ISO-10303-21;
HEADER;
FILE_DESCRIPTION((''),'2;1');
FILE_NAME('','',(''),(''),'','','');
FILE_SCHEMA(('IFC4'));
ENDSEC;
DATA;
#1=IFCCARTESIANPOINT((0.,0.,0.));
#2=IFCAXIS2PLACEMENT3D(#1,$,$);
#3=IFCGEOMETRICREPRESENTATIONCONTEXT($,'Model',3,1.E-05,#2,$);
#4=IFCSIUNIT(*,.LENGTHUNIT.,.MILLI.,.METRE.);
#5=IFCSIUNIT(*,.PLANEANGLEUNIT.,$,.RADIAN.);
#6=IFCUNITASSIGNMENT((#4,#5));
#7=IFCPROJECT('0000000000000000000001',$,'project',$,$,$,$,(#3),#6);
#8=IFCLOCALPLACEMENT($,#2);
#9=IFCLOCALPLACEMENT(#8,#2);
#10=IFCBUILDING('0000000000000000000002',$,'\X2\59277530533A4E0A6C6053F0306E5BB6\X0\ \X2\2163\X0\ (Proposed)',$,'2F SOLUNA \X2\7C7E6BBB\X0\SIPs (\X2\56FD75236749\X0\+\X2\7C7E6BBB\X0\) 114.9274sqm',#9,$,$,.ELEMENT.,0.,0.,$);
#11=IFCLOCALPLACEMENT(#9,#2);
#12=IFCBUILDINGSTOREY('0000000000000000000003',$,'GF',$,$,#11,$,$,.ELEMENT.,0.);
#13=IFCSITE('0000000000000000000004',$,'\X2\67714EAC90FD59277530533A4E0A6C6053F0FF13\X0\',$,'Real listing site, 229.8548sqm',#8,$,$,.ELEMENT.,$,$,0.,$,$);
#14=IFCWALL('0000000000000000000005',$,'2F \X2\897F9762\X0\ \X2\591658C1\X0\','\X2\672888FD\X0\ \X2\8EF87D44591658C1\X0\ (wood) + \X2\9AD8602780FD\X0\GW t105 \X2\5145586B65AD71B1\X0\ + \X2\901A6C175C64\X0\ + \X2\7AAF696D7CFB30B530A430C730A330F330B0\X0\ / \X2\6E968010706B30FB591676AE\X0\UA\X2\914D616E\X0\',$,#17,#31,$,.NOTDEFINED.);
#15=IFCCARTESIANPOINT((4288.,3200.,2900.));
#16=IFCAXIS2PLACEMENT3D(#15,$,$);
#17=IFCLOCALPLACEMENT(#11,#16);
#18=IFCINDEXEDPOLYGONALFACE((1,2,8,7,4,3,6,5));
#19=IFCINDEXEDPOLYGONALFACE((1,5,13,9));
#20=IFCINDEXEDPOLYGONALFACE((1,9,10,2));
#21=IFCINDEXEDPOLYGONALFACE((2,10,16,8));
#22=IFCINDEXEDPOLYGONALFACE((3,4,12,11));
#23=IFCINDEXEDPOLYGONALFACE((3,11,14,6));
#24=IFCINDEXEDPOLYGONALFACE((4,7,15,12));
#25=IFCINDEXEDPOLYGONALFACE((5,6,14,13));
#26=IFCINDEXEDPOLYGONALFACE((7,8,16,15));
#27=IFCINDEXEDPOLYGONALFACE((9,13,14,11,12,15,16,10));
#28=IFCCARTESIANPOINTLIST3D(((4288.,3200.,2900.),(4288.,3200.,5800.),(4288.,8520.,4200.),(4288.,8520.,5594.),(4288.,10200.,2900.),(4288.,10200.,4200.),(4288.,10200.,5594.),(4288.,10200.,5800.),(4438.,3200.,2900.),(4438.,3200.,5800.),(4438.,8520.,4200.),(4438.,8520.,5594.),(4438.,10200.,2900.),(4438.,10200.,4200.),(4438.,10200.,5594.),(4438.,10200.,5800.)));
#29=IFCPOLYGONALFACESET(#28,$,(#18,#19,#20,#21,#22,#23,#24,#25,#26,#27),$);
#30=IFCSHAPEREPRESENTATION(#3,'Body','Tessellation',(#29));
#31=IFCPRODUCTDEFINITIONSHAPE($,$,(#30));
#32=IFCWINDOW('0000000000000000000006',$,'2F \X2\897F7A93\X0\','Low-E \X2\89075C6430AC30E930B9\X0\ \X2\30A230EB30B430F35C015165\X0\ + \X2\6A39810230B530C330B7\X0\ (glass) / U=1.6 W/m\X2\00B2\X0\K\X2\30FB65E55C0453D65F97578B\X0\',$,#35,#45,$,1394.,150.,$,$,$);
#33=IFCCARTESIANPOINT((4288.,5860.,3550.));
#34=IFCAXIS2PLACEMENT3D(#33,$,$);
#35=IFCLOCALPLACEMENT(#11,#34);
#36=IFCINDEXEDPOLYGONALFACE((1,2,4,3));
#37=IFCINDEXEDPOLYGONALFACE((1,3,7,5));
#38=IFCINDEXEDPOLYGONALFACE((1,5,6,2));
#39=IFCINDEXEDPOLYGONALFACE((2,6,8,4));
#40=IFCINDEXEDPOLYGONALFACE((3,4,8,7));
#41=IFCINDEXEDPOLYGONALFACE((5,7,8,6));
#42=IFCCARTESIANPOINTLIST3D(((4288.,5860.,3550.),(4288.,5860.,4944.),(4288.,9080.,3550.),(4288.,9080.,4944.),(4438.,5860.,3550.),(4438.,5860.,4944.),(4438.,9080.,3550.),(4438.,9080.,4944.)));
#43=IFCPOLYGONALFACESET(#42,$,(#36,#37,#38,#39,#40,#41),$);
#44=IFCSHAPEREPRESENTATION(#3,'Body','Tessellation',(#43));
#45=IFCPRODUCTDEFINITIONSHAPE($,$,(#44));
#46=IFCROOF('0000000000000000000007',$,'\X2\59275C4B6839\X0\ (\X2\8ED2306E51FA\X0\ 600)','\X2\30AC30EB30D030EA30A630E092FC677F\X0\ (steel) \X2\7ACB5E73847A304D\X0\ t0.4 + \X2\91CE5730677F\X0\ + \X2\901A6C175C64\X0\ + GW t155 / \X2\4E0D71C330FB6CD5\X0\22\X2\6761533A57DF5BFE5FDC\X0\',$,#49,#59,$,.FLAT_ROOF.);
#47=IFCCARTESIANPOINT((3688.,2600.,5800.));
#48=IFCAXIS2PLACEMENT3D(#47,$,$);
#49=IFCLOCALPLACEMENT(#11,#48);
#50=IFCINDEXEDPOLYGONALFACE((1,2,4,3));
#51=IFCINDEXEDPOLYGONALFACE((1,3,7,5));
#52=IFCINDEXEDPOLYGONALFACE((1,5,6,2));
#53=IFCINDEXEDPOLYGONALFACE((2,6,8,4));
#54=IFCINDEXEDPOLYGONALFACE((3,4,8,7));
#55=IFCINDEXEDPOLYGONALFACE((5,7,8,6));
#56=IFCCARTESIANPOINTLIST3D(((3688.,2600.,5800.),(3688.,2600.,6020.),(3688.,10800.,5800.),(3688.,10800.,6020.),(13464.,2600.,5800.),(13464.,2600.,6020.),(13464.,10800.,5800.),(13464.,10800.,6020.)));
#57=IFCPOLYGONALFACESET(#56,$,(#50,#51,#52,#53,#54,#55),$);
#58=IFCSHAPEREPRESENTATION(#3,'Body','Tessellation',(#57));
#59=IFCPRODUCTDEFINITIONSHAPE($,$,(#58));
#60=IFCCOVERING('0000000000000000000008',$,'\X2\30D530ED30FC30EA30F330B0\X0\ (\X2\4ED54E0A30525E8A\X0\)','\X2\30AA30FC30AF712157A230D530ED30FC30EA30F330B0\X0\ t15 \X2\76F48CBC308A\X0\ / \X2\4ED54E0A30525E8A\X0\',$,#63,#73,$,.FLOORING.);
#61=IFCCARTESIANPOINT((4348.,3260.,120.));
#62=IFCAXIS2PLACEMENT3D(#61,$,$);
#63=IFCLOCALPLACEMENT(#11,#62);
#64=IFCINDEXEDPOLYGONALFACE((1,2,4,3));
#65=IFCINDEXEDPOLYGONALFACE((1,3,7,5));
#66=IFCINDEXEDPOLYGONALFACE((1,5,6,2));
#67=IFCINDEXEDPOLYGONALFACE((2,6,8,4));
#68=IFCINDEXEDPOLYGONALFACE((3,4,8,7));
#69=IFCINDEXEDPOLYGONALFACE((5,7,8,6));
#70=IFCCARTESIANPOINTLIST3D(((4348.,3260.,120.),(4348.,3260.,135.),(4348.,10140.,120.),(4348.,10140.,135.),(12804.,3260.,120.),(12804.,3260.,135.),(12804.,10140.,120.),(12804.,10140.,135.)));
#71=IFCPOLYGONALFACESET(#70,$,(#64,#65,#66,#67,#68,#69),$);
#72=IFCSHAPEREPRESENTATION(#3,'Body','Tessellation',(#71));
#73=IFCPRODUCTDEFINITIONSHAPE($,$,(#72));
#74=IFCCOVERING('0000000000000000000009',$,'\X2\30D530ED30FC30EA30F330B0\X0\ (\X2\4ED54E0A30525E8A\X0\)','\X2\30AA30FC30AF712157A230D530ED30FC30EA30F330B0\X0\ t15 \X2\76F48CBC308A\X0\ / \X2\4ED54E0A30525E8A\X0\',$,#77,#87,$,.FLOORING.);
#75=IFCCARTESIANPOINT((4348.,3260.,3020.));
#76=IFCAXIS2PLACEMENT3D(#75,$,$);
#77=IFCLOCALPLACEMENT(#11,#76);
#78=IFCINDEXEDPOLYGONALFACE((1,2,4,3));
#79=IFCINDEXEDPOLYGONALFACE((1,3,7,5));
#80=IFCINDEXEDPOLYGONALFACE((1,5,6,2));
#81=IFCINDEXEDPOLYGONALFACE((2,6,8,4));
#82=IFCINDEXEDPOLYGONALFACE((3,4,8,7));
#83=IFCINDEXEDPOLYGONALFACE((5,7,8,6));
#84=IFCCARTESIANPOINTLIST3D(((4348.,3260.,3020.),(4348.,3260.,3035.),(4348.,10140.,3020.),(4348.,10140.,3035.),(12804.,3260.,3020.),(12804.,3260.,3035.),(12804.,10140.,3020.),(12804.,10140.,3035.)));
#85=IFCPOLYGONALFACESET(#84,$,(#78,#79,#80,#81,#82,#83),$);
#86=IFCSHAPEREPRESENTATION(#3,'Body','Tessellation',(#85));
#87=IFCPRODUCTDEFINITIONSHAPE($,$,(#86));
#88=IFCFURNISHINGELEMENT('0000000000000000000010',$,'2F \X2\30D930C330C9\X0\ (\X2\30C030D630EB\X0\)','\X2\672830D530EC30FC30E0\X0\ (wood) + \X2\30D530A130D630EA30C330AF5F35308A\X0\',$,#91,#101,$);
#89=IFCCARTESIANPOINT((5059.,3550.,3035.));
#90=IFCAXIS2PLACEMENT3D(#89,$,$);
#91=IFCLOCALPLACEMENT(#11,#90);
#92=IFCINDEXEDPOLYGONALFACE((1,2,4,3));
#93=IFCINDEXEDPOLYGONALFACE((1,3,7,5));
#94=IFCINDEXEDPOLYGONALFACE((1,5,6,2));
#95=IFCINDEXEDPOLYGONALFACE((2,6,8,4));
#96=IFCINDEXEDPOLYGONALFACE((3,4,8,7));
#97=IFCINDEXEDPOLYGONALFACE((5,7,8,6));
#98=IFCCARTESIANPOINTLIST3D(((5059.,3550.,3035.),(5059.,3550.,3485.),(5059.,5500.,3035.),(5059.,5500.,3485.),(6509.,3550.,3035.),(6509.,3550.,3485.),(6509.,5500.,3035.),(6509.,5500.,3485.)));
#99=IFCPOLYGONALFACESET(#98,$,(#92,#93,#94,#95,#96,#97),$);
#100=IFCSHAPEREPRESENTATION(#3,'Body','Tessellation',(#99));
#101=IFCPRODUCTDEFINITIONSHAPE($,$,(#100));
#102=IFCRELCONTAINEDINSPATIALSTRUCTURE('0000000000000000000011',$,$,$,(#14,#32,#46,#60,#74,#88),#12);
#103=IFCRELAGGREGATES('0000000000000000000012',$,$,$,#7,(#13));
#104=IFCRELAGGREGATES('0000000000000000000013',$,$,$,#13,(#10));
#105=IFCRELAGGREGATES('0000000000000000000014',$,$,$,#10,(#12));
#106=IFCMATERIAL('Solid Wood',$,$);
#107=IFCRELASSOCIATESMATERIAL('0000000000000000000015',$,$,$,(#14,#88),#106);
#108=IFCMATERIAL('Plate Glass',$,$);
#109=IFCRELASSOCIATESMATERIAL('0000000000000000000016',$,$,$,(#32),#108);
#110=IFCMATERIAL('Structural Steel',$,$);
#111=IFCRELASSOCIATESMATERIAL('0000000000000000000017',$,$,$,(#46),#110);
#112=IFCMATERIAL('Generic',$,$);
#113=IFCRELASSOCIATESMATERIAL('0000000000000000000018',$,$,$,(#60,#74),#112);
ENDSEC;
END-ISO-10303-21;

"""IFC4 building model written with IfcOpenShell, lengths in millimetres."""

from ifc_helpers import new_model, si_unit, frame, frame_2d, origin, place, context, project, spatial, rectangle, extrude, material, element, fill, save


model = new_model("IFC4")

# Units and contexts
model_context = context("Model", 3, precision=1e-05, world=origin())
ifc_project = project(units=[si_unit("LENGTHUNIT", "METRE", prefix="MILLI"), si_unit("PLANEANGLEUNIT", "RADIAN")], contexts=[model_context])

# Site, building, storey
site_placement = place(None, origin())
site = spatial("IfcSite", under=ifc_project, at=site_placement, Name="東京都大田区上池台３", ObjectType="Real listing site, 229.8548sqm", CompositionType="ELEMENT", RefElevation=0.0)
building_placement = place(site_placement, origin())
building = spatial("IfcBuilding", under=site, at=building_placement, Name="大田区上池台の家 Ⅳ (Proposed)", ObjectType="2F SOLUNA 籾殻SIPs (国産杉+籾殻) 114.9274sqm", CompositionType="ELEMENT", ElevationOfRefHeight=0.0, ElevationOfTerrain=0.0)
storey_placement = place(building_placement, origin())
storey = spatial("IfcBuildingStorey", under=building, at=storey_placement, Name="GF", CompositionType="ELEMENT", Elevation=0.0)

# Shared definitions
ifc_material_1 = material(Name="Solid Wood")

# Shared definitions
ifc_material_2 = material(Name="Plate Glass")

# Wall, opening, window
wall_1_placement = place(storey_placement, frame((4288.0, 3200.0, 2900.0)))
wall_1 = element("IfcWall", 1, at=wall_1_placement, inside=storey, material=ifc_material_1, Name="2F 西面 外壁", Description="木製 軸組外壁 (wood) + 高性能GW t105 充填断熱 + 通気層 + 窯業系サイディング / 準耐火・外皮UA配慮", PredefinedType="NOTDEFINED", context=model_context, shape_type="SweptSolid", body=[
    extrude(rectangle(XDim=150.0, YDim=7000.0, at=frame_2d((75.0, 3500.0))), frame((4288.0, 3200.0, 2900.0)), (0.0, 0.0, 1.0), 2900.0),
])
opening_1_placement = place(storey_placement, frame((4288.0, 5860.0, 3550.0)))
opening_1 = element("IfcOpeningElement", 2, at=opening_1_placement, cuts=wall_1, PredefinedType="NOTDEFINED", context=model_context, shape_type="SweptSolid", body=[
    extrude(rectangle(XDim=150.0, YDim=3220.0, at=frame_2d((75.0, 1610.0))), frame((4288.0, 5860.0, 3550.0)), (0.0, 0.0, 1.0), 1394.0),
])
window_1_placement = place(storey_placement, frame((4288.0, 5860.0, 3550.0)))
window_1 = element("IfcWindow", 3, at=window_1_placement, inside=storey, material=ifc_material_2, Name="2F 西窓", Description="Low-E 複層ガラス アルゴン封入 + 樹脂サッシ (glass) / U=1.6 W/m²K・日射取得型", OverallHeight=1394.0, OverallWidth=150.0, context=model_context, shape_type="SweptSolid", body=[
    extrude(rectangle(XDim=150.0, YDim=3220.0, at=frame_2d((75.0, 1610.0))), frame((4288.0, 5860.0, 3550.0)), (0.0, 0.0, 1.0), 1394.0),
])
fill(opening_1, window_1)

# Roof
ifc_material_3 = material(Name="Structural Steel")
roof_placement = place(storey_placement, frame((3688.0, 2600.0, 5800.0)))
element("IfcRoof", 4, at=roof_placement, inside=storey, material=ifc_material_3, Name="大屋根 (軒の出 600)", Description="ガルバリウム鋼板 (steel) 立平葺き t0.4 + 野地板 + 通気層 + GW t155 / 不燃・法22条区域対応", PredefinedType="FLAT_ROOF", context=model_context, shape_type="SweptSolid", body=[
    extrude(rectangle(XDim=9776.0, YDim=8200.0, at=frame_2d((4888.0, 4100.0))), frame((3688.0, 2600.0, 5800.0)), (0.0, 0.0, 1.0), 220.0),
])

# Coverings
ifc_material_4 = material(Name="Generic")
covering_1_placement = place(storey_placement, frame((4348.0, 3260.0, 120.0)))
element("IfcCovering", 5, at=covering_1_placement, inside=storey, material=ifc_material_4, Name="フローリング (仕上げ床)", Description="オーク無垢フローリング t15 直貼り / 仕上げ床", PredefinedType="FLOORING", context=model_context, shape_type="SweptSolid", body=[
    extrude(rectangle(XDim=8456.0, YDim=6880.0, at=frame_2d((4228.0, 3440.0))), frame((4348.0, 3260.0, 120.0)), (0.0, 0.0, 1.0), 15.0),
])
covering_2_placement = place(storey_placement, frame((4348.0, 3260.0, 3020.0)))
element("IfcCovering", 6, at=covering_2_placement, inside=storey, material=ifc_material_4, Name="フローリング (仕上げ床)", Description="オーク無垢フローリング t15 直貼り / 仕上げ床", PredefinedType="FLOORING", context=model_context, shape_type="SweptSolid", body=[
    extrude(rectangle(XDim=8456.0, YDim=6880.0, at=frame_2d((4228.0, 3440.0))), frame((4348.0, 3260.0, 3020.0)), (0.0, 0.0, 1.0), 15.0),
])

# Furnishing element
furnishing_placement = place(storey_placement, frame((5059.0, 3550.0, 3035.0)))
element("IfcFurnishingElement", 7, at=furnishing_placement, inside=storey, material=ifc_material_1, Name="2F ベッド (ダブル)", Description="木フレーム (wood) + ファブリック張り", context=model_context, shape_type="SweptSolid", body=[
    extrude(rectangle(XDim=1450.0, YDim=1950.0, at=frame_2d((725.0, 975.0))), frame((5059.0, 3550.0, 3035.0)), (0.0, 0.0, 1.0), 450.0),
])

save(model, "model.ifc")
